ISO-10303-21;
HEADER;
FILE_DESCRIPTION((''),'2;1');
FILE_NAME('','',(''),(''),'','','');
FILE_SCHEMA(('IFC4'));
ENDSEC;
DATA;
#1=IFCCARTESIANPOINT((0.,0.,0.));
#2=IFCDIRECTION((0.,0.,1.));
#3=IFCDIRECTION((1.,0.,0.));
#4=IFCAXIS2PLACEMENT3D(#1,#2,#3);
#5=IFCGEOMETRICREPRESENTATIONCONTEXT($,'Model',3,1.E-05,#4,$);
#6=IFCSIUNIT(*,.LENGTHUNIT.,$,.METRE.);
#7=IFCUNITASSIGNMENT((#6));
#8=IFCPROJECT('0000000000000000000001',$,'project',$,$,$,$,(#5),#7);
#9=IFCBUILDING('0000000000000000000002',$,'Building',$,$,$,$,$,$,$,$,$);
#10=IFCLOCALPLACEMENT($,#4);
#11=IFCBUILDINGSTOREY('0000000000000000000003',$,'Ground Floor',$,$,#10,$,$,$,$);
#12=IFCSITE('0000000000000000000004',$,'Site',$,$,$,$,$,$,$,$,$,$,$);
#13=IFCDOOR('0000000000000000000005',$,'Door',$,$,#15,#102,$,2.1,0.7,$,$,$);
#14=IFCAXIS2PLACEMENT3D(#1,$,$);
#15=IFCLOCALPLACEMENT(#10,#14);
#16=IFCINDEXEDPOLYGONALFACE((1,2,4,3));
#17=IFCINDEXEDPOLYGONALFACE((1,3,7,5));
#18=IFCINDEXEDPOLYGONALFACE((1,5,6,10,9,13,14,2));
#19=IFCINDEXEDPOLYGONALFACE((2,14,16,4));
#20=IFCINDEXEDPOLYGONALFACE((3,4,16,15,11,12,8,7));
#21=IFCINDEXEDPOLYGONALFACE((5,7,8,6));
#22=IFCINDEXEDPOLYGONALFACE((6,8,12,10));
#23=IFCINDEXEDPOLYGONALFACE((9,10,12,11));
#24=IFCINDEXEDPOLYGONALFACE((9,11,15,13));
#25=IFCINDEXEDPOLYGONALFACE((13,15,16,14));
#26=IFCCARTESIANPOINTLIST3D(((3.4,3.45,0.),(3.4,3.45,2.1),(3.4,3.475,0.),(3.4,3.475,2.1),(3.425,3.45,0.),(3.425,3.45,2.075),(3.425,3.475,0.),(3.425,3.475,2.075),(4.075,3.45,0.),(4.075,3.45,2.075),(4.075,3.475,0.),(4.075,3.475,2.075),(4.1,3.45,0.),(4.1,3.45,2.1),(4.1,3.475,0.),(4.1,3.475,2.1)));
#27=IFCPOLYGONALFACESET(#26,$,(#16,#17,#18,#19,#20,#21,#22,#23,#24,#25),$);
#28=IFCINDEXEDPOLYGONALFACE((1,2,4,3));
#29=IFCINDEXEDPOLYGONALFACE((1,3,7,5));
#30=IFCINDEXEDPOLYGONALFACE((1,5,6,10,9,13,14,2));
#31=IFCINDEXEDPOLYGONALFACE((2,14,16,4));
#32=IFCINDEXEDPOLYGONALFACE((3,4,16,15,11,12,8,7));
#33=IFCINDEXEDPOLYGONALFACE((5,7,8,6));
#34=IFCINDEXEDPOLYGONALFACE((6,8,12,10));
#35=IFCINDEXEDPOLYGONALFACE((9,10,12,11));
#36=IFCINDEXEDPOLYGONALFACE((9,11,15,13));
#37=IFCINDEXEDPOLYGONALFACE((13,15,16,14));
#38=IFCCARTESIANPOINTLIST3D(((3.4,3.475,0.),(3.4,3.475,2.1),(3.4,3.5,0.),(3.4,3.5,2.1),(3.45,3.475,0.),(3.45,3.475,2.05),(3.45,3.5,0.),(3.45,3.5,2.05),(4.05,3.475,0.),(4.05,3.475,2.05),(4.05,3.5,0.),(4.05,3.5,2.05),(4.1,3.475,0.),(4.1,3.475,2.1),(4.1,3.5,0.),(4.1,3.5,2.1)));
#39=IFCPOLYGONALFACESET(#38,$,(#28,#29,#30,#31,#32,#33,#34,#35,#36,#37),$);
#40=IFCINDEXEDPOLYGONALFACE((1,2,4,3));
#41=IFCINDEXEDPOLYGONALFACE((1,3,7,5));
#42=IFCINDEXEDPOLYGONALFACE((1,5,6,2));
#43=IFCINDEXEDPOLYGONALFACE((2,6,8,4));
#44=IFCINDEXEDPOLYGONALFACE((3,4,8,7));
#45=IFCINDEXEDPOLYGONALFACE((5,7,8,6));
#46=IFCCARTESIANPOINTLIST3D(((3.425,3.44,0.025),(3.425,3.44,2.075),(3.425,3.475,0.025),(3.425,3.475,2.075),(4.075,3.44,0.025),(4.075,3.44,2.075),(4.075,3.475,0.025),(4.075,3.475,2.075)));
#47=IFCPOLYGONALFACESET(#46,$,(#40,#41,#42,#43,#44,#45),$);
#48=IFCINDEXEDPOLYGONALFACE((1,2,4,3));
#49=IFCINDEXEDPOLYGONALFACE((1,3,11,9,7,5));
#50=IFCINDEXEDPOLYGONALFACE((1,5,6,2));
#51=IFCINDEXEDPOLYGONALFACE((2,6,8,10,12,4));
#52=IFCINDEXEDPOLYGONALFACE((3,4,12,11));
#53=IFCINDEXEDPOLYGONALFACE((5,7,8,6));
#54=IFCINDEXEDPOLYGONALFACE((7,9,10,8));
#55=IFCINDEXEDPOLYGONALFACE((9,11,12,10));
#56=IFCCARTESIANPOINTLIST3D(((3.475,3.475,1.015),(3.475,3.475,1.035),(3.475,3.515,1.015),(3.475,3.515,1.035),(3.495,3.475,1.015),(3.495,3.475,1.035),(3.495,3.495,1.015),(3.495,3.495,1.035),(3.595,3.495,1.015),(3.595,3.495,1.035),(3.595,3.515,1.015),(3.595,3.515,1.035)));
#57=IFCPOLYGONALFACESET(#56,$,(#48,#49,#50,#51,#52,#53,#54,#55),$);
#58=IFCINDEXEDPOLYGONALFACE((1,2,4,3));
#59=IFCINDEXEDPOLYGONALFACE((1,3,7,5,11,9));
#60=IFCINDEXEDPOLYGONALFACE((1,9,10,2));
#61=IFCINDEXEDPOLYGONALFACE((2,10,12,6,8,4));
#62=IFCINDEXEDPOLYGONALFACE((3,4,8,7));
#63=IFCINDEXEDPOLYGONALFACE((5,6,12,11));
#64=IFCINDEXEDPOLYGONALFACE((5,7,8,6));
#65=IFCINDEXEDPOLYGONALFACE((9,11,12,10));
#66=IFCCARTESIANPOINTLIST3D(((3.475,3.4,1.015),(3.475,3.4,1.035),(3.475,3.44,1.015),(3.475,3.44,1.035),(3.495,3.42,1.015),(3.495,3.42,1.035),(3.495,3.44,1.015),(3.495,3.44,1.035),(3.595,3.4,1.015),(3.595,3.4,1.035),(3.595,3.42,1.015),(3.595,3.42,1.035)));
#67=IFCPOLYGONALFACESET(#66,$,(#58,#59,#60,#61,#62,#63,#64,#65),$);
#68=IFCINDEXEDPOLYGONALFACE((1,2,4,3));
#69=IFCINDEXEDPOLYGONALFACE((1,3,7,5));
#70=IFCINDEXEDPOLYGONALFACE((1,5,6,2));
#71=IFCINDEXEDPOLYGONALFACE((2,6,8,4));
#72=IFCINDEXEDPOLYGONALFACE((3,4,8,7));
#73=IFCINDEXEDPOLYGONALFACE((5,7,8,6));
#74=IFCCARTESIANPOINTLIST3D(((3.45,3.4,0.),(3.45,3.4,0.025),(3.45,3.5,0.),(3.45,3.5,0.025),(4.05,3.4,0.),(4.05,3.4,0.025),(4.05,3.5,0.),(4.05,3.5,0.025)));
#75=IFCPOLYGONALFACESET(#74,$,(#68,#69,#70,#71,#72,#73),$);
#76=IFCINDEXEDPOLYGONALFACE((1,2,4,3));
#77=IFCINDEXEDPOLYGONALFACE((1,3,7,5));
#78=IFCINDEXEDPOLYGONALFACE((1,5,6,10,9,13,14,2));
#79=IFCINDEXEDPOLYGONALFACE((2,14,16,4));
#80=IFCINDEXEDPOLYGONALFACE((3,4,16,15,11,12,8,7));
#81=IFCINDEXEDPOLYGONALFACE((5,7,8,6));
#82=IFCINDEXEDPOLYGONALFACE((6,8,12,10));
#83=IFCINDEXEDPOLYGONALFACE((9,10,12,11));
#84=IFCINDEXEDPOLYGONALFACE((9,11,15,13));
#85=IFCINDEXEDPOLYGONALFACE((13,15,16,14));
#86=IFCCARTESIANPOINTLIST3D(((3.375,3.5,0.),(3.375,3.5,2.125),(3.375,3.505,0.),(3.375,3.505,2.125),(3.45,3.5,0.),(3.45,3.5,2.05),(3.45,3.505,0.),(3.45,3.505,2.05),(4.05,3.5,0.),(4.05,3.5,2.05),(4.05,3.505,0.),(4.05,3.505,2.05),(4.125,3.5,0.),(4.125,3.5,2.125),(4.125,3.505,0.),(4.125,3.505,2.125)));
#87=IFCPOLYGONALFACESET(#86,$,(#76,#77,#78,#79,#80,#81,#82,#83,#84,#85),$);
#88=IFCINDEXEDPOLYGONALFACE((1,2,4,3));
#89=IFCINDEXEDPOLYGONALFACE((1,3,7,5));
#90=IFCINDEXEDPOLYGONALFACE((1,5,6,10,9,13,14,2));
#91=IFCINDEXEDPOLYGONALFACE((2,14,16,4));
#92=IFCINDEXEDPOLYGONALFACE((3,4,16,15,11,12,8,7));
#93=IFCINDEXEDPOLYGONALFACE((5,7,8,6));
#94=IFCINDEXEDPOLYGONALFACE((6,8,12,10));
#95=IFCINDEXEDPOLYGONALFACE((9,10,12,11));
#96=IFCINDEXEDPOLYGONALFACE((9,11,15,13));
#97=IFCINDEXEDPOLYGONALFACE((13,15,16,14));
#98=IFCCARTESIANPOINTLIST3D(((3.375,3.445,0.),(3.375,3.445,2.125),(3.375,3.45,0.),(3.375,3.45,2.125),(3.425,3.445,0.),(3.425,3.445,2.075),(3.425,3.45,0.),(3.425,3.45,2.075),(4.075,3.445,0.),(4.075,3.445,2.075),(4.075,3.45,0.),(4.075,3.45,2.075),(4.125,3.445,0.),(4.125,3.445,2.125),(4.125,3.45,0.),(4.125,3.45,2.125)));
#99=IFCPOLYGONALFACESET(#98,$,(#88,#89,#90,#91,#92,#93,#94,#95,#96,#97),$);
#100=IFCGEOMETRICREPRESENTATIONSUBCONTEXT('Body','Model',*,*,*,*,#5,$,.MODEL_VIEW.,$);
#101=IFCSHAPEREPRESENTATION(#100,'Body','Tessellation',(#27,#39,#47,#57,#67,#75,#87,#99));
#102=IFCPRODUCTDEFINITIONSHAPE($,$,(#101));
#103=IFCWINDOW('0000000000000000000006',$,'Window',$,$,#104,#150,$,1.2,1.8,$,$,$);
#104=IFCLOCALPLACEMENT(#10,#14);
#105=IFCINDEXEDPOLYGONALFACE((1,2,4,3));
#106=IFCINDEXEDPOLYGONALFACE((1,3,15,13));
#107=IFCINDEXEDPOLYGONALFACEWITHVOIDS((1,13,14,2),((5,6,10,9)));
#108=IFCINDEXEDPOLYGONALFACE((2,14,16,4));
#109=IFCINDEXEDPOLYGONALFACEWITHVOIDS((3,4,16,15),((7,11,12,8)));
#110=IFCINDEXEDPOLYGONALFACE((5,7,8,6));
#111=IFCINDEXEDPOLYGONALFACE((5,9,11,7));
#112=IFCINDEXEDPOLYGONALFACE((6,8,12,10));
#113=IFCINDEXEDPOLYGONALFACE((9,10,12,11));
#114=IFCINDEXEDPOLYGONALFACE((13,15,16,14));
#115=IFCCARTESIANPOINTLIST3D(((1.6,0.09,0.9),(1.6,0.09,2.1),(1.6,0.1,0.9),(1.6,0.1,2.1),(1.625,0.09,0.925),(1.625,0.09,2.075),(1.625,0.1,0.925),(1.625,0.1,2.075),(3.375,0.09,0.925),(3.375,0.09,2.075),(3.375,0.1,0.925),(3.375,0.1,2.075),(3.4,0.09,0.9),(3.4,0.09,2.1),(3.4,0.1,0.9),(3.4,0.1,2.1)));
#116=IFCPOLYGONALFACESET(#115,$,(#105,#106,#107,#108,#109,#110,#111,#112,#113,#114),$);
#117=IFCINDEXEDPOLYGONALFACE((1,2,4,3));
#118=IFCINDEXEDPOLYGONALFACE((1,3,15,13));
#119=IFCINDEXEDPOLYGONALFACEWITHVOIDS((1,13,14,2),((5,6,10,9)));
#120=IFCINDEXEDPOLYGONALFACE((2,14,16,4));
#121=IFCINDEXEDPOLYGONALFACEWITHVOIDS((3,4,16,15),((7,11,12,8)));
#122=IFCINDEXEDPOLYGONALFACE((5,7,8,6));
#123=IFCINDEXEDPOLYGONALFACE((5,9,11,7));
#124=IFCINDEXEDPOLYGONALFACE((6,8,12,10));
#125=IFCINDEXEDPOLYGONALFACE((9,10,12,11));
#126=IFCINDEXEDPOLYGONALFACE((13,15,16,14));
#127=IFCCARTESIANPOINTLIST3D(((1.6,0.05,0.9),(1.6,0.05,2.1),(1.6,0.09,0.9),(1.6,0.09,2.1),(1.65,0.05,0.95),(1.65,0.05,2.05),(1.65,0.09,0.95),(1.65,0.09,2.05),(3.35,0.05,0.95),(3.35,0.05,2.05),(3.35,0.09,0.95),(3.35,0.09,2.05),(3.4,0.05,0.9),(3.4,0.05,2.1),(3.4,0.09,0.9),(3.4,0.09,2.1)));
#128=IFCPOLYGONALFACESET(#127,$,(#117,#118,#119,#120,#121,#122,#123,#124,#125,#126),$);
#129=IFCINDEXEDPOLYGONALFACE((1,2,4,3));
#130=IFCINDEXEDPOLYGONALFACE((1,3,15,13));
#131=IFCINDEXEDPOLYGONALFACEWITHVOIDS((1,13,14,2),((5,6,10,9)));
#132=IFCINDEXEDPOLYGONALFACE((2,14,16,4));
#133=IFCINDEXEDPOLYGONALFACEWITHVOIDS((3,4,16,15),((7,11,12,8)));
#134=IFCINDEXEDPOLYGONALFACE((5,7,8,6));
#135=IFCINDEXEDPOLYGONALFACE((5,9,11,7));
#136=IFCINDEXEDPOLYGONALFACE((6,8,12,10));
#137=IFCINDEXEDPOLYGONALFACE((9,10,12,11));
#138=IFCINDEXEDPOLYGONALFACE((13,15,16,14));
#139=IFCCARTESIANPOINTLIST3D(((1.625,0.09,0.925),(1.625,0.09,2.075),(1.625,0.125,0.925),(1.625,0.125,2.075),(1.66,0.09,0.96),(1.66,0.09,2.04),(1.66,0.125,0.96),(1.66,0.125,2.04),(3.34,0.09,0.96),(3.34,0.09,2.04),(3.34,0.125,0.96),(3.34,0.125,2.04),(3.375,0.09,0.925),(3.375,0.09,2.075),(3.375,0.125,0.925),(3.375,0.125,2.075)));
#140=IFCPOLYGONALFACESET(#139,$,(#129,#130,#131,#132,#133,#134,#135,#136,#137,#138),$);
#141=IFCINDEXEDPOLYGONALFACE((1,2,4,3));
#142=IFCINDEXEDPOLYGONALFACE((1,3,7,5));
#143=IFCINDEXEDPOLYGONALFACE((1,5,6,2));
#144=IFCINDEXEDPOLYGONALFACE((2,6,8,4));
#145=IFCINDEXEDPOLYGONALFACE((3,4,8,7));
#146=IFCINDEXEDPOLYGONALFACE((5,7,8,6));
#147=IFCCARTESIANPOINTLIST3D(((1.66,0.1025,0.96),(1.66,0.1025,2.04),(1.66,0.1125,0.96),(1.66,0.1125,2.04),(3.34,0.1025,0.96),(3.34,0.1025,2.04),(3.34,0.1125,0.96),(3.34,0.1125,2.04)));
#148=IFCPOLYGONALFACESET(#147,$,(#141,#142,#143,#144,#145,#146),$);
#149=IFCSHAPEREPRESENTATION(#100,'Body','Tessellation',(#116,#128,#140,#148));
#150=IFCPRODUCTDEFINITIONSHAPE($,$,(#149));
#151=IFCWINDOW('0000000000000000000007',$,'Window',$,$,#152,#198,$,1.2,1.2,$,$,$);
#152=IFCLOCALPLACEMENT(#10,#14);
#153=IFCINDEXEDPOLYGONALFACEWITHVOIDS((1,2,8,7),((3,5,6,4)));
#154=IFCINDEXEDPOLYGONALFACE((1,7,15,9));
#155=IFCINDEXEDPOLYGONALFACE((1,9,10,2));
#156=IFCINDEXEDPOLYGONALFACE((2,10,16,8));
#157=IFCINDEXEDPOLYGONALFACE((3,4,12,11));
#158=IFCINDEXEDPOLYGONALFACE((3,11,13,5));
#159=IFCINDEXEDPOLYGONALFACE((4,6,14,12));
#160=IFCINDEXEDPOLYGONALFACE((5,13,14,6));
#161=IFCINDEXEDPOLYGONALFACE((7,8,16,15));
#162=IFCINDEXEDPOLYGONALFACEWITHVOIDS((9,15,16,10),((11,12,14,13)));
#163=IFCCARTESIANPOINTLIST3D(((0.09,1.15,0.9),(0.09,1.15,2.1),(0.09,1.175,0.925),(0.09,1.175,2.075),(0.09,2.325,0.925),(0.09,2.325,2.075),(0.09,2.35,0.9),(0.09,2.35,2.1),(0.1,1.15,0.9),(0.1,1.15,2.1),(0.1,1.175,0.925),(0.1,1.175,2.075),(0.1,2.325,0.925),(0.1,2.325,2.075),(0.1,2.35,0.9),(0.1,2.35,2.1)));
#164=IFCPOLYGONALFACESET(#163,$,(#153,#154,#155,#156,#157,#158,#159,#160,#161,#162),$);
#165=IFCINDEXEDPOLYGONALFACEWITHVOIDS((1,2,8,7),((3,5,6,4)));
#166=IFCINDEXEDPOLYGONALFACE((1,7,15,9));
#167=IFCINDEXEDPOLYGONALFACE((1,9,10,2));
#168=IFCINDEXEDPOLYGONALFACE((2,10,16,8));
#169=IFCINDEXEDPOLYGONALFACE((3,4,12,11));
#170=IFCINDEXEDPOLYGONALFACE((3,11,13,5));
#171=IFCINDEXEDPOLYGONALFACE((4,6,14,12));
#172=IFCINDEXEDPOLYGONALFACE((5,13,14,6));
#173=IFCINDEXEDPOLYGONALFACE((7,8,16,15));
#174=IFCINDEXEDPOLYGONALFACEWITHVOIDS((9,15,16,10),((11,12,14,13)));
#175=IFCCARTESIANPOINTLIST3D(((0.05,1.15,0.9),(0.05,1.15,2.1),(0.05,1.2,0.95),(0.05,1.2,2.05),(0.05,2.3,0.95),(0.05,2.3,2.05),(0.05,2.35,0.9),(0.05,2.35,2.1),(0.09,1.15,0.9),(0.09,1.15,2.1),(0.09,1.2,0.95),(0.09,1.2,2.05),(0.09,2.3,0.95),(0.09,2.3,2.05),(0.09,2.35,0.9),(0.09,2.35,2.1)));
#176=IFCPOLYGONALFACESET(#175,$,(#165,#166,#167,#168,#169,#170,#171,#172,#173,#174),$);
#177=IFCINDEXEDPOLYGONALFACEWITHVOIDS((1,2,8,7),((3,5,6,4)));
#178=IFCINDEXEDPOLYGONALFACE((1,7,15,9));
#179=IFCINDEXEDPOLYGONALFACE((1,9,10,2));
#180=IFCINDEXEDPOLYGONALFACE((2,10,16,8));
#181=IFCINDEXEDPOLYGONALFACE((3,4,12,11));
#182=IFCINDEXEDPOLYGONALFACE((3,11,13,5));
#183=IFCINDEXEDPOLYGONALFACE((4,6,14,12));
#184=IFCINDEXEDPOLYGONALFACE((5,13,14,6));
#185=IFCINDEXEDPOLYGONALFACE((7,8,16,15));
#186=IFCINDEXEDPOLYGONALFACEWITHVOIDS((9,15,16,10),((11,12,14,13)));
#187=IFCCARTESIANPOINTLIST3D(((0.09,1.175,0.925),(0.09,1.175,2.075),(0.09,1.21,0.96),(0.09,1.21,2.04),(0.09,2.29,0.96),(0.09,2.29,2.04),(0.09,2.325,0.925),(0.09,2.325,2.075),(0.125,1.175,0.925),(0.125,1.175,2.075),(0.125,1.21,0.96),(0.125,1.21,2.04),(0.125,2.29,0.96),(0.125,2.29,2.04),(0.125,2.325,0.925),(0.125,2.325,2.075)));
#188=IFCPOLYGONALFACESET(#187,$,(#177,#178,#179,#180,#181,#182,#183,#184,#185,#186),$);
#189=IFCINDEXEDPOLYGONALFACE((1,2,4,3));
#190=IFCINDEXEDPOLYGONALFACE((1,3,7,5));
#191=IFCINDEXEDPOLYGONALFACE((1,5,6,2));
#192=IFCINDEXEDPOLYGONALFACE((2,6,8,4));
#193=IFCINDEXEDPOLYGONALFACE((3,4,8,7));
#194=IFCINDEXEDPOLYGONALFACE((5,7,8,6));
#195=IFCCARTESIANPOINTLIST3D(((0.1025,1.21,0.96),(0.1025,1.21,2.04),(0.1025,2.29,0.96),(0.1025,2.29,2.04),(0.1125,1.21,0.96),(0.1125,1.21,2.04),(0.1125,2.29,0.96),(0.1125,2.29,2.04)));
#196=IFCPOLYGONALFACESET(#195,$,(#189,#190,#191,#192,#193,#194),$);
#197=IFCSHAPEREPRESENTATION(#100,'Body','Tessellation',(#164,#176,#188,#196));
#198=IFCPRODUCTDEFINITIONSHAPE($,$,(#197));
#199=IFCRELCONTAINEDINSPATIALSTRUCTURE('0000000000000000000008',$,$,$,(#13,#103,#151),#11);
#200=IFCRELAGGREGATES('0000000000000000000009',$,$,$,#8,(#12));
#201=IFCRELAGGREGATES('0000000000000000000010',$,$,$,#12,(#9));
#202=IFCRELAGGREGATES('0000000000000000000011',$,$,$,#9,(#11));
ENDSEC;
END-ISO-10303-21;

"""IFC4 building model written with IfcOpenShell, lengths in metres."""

from ifc_helpers import new_model, si_unit, frame, origin_with_axes, place, context, subcontext, project, spatial, line, indexed_curve, outline, extrude, element, save


model = new_model("IFC4")

# Units and contexts
model_context = context("Model", 3, precision=1e-05, world=origin_with_axes())
body_context = subcontext(model_context, "Body", "Model", "MODEL_VIEW")
ifc_project = project(units=[si_unit("LENGTHUNIT", "METRE")], contexts=[model_context])

# Site, building, storey
site = spatial("IfcSite", under=ifc_project, Name="Site")
building = spatial("IfcBuilding", under=site, Name="Building")
storey_placement = place(None, origin_with_axes())
storey = spatial("IfcBuildingStorey", under=building, at=storey_placement, Name="Ground Floor")

# Door
door_1_placement = place(storey_placement, frame((4.1, 3.5, 0.0), z_axis=(0.0, 0.0, 1.0), x_axis=(-1.0, 0.0, 0.0)))
element("IfcDoor", 1, at=door_1_placement, inside=storey, Name="Door", OverallHeight=2.1, OverallWidth=0.7, context=body_context, shape_type="SweptSolid", body=[
    extrude(outline(indexed_curve([(0.0, 0.0), (0.0, 2.1), (0.7, 2.1), (0.7, 0.0), (0.675, 0.0), (0.675, 2.075), (0.025, 2.075), (0.025, 0.0)], segments=[line(1, 2, 3, 4, 5, 6, 7, 8, 1)])), frame((0.0, 0.025, 0.0), z_axis=(0.0, -1.0, 0.0), x_axis=(1.0, 0.0, 0.0)), (0.0, 0.0, -1.0), 0.025),
    extrude(outline(indexed_curve([(0.0, 0.0), (0.0, 2.1), (0.7, 2.1), (0.7, 0.0), (0.65, 0.0), (0.65, 2.05), (0.05, 2.05), (0.05, 0.0)], segments=[line(1, 2, 3, 4, 5, 6, 7, 8, 1)])), frame((0.0, 0.0, 0.0), z_axis=(0.0, -1.0, 0.0), x_axis=(1.0, 0.0, 0.0)), (0.0, 0.0, -1.0), 0.025),
    extrude(outline(indexed_curve([(0.0, 0.0), (0.65, 0.0), (0.65, 0.035), (0.0, 0.035)], segments=[line(1, 2, 3, 4, 1)])), frame((0.025, 0.025, 0.025), z_axis=(0.0, 0.0, 1.0), x_axis=(1.0, 0.0, 0.0)), (0.0, 0.0, 1.0), 2.05),
    extrude(outline(indexed_curve([(0.0, 0.0), (0.0, -0.04), (-0.12, -0.04), (-0.12, -0.02), (-0.02, -0.02), (-0.02, 0.0)], segments=[line(1, 2, 3, 4, 5, 6, 1)])), frame((0.625, 0.025, 1.015), z_axis=(0.0, 0.0, 1.0), x_axis=(1.0, 0.0, 0.0)), (0.0, 0.0, 1.0), 0.02),
    extrude(outline(indexed_curve([(0.0, 0.0), (0.0, 0.04), (-0.12, 0.04), (-0.12, 0.02), (-0.02, 0.02), (-0.02, 0.0)], segments=[line(1, 2, 3, 4, 5, 6, 1)])), frame((0.625, 0.06, 1.015), z_axis=(0.0, 0.0, 1.0), x_axis=(1.0, 0.0, 0.0)), (0.0, 0.0, 1.0), 0.02),
    extrude(outline(indexed_curve([(0.0, 0.0), (0.6, 0.0), (0.6, 0.1), (0.0, 0.1)], segments=[line(1, 2, 3, 4, 1)])), frame((0.05, 0.0, 0.0), z_axis=(0.0, 0.0, 1.0), x_axis=(1.0, 0.0, 0.0)), (0.0, 0.0, 1.0), 0.025),
    extrude(outline(indexed_curve([(0.0, 0.0), (0.0, 2.125), (0.75, 2.125), (0.75, 0.0), (0.675, 0.0), (0.675, 2.05), (0.075, 2.05), (0.075, 0.0)], segments=[line(1, 2, 3, 4, 5, 6, 7, 8, 1)])), frame((-0.025, -0.005, 0.0), z_axis=(0.0, -1.0, 0.0), x_axis=(1.0, 0.0, 0.0)), (0.0, 0.0, -1.0), 0.005),
    extrude(outline(indexed_curve([(0.0, 0.0), (0.0, 2.125), (0.75, 2.125), (0.75, 0.0), (0.7, 0.0), (0.7, 2.075), (0.05, 2.075), (0.05, 0.0)], segments=[line(1, 2, 3, 4, 5, 6, 7, 8, 1)])), frame((-0.025, 0.05, 0.0), z_axis=(0.0, -1.0, 0.0), x_axis=(1.0, 0.0, 0.0)), (0.0, 0.0, -1.0), 0.005),
])

# Windows
window_1_placement = place(storey_placement, frame((1.6, 0.0, 0.9), z_axis=(0.0, 0.0, 1.0), x_axis=(1.0, 0.0, 0.0)))
element("IfcWindow", 2, at=window_1_placement, inside=storey, Name="Window", OverallHeight=1.2, OverallWidth=1.8, context=body_context, shape_type="SweptSolid", body=[
    extrude(outline(indexed_curve([(0.0, 0.0), (1.8, 0.0), (1.8, 1.2), (0.0, 1.2)], segments=[line(1, 2, 3, 4, 1)]), holes=[indexed_curve([(0.025, 0.025), (1.775, 0.025), (1.775, 1.175), (0.025, 1.175)], segments=[line(1, 2, 3, 4, 1)])]), frame((0.0, 0.09, 0.0), z_axis=(0.0, -1.0, 0.0), x_axis=(1.0, 0.0, 0.0)), (0.0, 0.0, -1.0), 0.01),
    extrude(outline(indexed_curve([(0.0, 0.0), (1.8, 0.0), (1.8, 1.2), (0.0, 1.2)], segments=[line(1, 2, 3, 4, 1)]), holes=[indexed_curve([(0.05, 0.05), (1.75, 0.05), (1.75, 1.15), (0.05, 1.15)], segments=[line(1, 2, 3, 4, 1)])]), frame((0.0, 0.05, 0.0), z_axis=(0.0, -1.0, 0.0), x_axis=(1.0, 0.0, 0.0)), (0.0, 0.0, -1.0), 0.04),
    extrude(outline(indexed_curve([(0.0, 0.0), (1.75, 0.0), (1.75, 1.15), (0.0, 1.15)], segments=[line(1, 2, 3, 4, 1)]), holes=[indexed_curve([(0.035, 0.035), (1.715, 0.035), (1.715, 1.115), (0.035, 1.115)], segments=[line(1, 2, 3, 4, 1)])]), frame((0.025, 0.09, 0.025), z_axis=(0.0, -1.0, 0.0), x_axis=(1.0, 0.0, 0.0)), (0.0, 0.0, -1.0), 0.035),
    extrude(outline(indexed_curve([(0.035, 0.035), (1.715, 0.035), (1.715, 1.115), (0.035, 1.115)], segments=[line(1, 2, 3, 4, 1)])), frame((0.025, 0.1025, 0.025), z_axis=(0.0, -1.0, 0.0), x_axis=(1.0, 0.0, 0.0)), (0.0, 0.0, -1.0), 0.01),
])
for number, where, z_axis, x_axis, name in (
    (3, (0.0, 2.35, 0.9), (0.0, 0.0, 1.0), (0.0, -1.0, 0.0), "Window"),
):
    element("IfcWindow", number, at=place(storey_placement, frame(where, z_axis=z_axis, x_axis=x_axis)), inside=storey, Name=name, OverallHeight=1.2, OverallWidth=1.2, context=body_context, shape_type="SweptSolid", body=[
        extrude(outline(indexed_curve([(0.0, 0.0), (1.2, 0.0), (1.2, 1.2), (0.0, 1.2)], segments=[line(1, 2, 3, 4, 1)]), holes=[indexed_curve([(0.025, 0.025), (1.175, 0.025), (1.175, 1.175), (0.025, 1.175)], segments=[line(1, 2, 3, 4, 1)])]), frame((0.0, 0.09, 0.0), z_axis=(0.0, -1.0, 0.0), x_axis=(1.0, 0.0, 0.0)), (0.0, 0.0, -1.0), 0.01),
        extrude(outline(indexed_curve([(0.0, 0.0), (1.2, 0.0), (1.2, 1.2), (0.0, 1.2)], segments=[line(1, 2, 3, 4, 1)]), holes=[indexed_curve([(0.05, 0.05), (1.15, 0.05), (1.15, 1.15), (0.05, 1.15)], segments=[line(1, 2, 3, 4, 1)])]), frame((0.0, 0.05, 0.0), z_axis=(0.0, -1.0, 0.0), x_axis=(1.0, 0.0, 0.0)), (0.0, 0.0, -1.0), 0.04),
        extrude(outline(indexed_curve([(0.0, 0.0), (1.15, 0.0), (1.15, 1.15), (0.0, 1.15)], segments=[line(1, 2, 3, 4, 1)]), holes=[indexed_curve([(0.035, 0.035), (1.115, 0.035), (1.115, 1.115), (0.035, 1.115)], segments=[line(1, 2, 3, 4, 1)])]), frame((0.025, 0.09, 0.025), z_axis=(0.0, -1.0, 0.0), x_axis=(1.0, 0.0, 0.0)), (0.0, 0.0, -1.0), 0.035),
        extrude(outline(indexed_curve([(0.035, 0.035), (1.115, 0.035), (1.115, 1.115), (0.035, 1.115)], segments=[line(1, 2, 3, 4, 1)])), frame((0.025, 0.1025, 0.025), z_axis=(0.0, -1.0, 0.0), x_axis=(1.0, 0.0, 0.0)), (0.0, 0.0, -1.0), 0.01),
    ])

save(model, "model.ifc")
